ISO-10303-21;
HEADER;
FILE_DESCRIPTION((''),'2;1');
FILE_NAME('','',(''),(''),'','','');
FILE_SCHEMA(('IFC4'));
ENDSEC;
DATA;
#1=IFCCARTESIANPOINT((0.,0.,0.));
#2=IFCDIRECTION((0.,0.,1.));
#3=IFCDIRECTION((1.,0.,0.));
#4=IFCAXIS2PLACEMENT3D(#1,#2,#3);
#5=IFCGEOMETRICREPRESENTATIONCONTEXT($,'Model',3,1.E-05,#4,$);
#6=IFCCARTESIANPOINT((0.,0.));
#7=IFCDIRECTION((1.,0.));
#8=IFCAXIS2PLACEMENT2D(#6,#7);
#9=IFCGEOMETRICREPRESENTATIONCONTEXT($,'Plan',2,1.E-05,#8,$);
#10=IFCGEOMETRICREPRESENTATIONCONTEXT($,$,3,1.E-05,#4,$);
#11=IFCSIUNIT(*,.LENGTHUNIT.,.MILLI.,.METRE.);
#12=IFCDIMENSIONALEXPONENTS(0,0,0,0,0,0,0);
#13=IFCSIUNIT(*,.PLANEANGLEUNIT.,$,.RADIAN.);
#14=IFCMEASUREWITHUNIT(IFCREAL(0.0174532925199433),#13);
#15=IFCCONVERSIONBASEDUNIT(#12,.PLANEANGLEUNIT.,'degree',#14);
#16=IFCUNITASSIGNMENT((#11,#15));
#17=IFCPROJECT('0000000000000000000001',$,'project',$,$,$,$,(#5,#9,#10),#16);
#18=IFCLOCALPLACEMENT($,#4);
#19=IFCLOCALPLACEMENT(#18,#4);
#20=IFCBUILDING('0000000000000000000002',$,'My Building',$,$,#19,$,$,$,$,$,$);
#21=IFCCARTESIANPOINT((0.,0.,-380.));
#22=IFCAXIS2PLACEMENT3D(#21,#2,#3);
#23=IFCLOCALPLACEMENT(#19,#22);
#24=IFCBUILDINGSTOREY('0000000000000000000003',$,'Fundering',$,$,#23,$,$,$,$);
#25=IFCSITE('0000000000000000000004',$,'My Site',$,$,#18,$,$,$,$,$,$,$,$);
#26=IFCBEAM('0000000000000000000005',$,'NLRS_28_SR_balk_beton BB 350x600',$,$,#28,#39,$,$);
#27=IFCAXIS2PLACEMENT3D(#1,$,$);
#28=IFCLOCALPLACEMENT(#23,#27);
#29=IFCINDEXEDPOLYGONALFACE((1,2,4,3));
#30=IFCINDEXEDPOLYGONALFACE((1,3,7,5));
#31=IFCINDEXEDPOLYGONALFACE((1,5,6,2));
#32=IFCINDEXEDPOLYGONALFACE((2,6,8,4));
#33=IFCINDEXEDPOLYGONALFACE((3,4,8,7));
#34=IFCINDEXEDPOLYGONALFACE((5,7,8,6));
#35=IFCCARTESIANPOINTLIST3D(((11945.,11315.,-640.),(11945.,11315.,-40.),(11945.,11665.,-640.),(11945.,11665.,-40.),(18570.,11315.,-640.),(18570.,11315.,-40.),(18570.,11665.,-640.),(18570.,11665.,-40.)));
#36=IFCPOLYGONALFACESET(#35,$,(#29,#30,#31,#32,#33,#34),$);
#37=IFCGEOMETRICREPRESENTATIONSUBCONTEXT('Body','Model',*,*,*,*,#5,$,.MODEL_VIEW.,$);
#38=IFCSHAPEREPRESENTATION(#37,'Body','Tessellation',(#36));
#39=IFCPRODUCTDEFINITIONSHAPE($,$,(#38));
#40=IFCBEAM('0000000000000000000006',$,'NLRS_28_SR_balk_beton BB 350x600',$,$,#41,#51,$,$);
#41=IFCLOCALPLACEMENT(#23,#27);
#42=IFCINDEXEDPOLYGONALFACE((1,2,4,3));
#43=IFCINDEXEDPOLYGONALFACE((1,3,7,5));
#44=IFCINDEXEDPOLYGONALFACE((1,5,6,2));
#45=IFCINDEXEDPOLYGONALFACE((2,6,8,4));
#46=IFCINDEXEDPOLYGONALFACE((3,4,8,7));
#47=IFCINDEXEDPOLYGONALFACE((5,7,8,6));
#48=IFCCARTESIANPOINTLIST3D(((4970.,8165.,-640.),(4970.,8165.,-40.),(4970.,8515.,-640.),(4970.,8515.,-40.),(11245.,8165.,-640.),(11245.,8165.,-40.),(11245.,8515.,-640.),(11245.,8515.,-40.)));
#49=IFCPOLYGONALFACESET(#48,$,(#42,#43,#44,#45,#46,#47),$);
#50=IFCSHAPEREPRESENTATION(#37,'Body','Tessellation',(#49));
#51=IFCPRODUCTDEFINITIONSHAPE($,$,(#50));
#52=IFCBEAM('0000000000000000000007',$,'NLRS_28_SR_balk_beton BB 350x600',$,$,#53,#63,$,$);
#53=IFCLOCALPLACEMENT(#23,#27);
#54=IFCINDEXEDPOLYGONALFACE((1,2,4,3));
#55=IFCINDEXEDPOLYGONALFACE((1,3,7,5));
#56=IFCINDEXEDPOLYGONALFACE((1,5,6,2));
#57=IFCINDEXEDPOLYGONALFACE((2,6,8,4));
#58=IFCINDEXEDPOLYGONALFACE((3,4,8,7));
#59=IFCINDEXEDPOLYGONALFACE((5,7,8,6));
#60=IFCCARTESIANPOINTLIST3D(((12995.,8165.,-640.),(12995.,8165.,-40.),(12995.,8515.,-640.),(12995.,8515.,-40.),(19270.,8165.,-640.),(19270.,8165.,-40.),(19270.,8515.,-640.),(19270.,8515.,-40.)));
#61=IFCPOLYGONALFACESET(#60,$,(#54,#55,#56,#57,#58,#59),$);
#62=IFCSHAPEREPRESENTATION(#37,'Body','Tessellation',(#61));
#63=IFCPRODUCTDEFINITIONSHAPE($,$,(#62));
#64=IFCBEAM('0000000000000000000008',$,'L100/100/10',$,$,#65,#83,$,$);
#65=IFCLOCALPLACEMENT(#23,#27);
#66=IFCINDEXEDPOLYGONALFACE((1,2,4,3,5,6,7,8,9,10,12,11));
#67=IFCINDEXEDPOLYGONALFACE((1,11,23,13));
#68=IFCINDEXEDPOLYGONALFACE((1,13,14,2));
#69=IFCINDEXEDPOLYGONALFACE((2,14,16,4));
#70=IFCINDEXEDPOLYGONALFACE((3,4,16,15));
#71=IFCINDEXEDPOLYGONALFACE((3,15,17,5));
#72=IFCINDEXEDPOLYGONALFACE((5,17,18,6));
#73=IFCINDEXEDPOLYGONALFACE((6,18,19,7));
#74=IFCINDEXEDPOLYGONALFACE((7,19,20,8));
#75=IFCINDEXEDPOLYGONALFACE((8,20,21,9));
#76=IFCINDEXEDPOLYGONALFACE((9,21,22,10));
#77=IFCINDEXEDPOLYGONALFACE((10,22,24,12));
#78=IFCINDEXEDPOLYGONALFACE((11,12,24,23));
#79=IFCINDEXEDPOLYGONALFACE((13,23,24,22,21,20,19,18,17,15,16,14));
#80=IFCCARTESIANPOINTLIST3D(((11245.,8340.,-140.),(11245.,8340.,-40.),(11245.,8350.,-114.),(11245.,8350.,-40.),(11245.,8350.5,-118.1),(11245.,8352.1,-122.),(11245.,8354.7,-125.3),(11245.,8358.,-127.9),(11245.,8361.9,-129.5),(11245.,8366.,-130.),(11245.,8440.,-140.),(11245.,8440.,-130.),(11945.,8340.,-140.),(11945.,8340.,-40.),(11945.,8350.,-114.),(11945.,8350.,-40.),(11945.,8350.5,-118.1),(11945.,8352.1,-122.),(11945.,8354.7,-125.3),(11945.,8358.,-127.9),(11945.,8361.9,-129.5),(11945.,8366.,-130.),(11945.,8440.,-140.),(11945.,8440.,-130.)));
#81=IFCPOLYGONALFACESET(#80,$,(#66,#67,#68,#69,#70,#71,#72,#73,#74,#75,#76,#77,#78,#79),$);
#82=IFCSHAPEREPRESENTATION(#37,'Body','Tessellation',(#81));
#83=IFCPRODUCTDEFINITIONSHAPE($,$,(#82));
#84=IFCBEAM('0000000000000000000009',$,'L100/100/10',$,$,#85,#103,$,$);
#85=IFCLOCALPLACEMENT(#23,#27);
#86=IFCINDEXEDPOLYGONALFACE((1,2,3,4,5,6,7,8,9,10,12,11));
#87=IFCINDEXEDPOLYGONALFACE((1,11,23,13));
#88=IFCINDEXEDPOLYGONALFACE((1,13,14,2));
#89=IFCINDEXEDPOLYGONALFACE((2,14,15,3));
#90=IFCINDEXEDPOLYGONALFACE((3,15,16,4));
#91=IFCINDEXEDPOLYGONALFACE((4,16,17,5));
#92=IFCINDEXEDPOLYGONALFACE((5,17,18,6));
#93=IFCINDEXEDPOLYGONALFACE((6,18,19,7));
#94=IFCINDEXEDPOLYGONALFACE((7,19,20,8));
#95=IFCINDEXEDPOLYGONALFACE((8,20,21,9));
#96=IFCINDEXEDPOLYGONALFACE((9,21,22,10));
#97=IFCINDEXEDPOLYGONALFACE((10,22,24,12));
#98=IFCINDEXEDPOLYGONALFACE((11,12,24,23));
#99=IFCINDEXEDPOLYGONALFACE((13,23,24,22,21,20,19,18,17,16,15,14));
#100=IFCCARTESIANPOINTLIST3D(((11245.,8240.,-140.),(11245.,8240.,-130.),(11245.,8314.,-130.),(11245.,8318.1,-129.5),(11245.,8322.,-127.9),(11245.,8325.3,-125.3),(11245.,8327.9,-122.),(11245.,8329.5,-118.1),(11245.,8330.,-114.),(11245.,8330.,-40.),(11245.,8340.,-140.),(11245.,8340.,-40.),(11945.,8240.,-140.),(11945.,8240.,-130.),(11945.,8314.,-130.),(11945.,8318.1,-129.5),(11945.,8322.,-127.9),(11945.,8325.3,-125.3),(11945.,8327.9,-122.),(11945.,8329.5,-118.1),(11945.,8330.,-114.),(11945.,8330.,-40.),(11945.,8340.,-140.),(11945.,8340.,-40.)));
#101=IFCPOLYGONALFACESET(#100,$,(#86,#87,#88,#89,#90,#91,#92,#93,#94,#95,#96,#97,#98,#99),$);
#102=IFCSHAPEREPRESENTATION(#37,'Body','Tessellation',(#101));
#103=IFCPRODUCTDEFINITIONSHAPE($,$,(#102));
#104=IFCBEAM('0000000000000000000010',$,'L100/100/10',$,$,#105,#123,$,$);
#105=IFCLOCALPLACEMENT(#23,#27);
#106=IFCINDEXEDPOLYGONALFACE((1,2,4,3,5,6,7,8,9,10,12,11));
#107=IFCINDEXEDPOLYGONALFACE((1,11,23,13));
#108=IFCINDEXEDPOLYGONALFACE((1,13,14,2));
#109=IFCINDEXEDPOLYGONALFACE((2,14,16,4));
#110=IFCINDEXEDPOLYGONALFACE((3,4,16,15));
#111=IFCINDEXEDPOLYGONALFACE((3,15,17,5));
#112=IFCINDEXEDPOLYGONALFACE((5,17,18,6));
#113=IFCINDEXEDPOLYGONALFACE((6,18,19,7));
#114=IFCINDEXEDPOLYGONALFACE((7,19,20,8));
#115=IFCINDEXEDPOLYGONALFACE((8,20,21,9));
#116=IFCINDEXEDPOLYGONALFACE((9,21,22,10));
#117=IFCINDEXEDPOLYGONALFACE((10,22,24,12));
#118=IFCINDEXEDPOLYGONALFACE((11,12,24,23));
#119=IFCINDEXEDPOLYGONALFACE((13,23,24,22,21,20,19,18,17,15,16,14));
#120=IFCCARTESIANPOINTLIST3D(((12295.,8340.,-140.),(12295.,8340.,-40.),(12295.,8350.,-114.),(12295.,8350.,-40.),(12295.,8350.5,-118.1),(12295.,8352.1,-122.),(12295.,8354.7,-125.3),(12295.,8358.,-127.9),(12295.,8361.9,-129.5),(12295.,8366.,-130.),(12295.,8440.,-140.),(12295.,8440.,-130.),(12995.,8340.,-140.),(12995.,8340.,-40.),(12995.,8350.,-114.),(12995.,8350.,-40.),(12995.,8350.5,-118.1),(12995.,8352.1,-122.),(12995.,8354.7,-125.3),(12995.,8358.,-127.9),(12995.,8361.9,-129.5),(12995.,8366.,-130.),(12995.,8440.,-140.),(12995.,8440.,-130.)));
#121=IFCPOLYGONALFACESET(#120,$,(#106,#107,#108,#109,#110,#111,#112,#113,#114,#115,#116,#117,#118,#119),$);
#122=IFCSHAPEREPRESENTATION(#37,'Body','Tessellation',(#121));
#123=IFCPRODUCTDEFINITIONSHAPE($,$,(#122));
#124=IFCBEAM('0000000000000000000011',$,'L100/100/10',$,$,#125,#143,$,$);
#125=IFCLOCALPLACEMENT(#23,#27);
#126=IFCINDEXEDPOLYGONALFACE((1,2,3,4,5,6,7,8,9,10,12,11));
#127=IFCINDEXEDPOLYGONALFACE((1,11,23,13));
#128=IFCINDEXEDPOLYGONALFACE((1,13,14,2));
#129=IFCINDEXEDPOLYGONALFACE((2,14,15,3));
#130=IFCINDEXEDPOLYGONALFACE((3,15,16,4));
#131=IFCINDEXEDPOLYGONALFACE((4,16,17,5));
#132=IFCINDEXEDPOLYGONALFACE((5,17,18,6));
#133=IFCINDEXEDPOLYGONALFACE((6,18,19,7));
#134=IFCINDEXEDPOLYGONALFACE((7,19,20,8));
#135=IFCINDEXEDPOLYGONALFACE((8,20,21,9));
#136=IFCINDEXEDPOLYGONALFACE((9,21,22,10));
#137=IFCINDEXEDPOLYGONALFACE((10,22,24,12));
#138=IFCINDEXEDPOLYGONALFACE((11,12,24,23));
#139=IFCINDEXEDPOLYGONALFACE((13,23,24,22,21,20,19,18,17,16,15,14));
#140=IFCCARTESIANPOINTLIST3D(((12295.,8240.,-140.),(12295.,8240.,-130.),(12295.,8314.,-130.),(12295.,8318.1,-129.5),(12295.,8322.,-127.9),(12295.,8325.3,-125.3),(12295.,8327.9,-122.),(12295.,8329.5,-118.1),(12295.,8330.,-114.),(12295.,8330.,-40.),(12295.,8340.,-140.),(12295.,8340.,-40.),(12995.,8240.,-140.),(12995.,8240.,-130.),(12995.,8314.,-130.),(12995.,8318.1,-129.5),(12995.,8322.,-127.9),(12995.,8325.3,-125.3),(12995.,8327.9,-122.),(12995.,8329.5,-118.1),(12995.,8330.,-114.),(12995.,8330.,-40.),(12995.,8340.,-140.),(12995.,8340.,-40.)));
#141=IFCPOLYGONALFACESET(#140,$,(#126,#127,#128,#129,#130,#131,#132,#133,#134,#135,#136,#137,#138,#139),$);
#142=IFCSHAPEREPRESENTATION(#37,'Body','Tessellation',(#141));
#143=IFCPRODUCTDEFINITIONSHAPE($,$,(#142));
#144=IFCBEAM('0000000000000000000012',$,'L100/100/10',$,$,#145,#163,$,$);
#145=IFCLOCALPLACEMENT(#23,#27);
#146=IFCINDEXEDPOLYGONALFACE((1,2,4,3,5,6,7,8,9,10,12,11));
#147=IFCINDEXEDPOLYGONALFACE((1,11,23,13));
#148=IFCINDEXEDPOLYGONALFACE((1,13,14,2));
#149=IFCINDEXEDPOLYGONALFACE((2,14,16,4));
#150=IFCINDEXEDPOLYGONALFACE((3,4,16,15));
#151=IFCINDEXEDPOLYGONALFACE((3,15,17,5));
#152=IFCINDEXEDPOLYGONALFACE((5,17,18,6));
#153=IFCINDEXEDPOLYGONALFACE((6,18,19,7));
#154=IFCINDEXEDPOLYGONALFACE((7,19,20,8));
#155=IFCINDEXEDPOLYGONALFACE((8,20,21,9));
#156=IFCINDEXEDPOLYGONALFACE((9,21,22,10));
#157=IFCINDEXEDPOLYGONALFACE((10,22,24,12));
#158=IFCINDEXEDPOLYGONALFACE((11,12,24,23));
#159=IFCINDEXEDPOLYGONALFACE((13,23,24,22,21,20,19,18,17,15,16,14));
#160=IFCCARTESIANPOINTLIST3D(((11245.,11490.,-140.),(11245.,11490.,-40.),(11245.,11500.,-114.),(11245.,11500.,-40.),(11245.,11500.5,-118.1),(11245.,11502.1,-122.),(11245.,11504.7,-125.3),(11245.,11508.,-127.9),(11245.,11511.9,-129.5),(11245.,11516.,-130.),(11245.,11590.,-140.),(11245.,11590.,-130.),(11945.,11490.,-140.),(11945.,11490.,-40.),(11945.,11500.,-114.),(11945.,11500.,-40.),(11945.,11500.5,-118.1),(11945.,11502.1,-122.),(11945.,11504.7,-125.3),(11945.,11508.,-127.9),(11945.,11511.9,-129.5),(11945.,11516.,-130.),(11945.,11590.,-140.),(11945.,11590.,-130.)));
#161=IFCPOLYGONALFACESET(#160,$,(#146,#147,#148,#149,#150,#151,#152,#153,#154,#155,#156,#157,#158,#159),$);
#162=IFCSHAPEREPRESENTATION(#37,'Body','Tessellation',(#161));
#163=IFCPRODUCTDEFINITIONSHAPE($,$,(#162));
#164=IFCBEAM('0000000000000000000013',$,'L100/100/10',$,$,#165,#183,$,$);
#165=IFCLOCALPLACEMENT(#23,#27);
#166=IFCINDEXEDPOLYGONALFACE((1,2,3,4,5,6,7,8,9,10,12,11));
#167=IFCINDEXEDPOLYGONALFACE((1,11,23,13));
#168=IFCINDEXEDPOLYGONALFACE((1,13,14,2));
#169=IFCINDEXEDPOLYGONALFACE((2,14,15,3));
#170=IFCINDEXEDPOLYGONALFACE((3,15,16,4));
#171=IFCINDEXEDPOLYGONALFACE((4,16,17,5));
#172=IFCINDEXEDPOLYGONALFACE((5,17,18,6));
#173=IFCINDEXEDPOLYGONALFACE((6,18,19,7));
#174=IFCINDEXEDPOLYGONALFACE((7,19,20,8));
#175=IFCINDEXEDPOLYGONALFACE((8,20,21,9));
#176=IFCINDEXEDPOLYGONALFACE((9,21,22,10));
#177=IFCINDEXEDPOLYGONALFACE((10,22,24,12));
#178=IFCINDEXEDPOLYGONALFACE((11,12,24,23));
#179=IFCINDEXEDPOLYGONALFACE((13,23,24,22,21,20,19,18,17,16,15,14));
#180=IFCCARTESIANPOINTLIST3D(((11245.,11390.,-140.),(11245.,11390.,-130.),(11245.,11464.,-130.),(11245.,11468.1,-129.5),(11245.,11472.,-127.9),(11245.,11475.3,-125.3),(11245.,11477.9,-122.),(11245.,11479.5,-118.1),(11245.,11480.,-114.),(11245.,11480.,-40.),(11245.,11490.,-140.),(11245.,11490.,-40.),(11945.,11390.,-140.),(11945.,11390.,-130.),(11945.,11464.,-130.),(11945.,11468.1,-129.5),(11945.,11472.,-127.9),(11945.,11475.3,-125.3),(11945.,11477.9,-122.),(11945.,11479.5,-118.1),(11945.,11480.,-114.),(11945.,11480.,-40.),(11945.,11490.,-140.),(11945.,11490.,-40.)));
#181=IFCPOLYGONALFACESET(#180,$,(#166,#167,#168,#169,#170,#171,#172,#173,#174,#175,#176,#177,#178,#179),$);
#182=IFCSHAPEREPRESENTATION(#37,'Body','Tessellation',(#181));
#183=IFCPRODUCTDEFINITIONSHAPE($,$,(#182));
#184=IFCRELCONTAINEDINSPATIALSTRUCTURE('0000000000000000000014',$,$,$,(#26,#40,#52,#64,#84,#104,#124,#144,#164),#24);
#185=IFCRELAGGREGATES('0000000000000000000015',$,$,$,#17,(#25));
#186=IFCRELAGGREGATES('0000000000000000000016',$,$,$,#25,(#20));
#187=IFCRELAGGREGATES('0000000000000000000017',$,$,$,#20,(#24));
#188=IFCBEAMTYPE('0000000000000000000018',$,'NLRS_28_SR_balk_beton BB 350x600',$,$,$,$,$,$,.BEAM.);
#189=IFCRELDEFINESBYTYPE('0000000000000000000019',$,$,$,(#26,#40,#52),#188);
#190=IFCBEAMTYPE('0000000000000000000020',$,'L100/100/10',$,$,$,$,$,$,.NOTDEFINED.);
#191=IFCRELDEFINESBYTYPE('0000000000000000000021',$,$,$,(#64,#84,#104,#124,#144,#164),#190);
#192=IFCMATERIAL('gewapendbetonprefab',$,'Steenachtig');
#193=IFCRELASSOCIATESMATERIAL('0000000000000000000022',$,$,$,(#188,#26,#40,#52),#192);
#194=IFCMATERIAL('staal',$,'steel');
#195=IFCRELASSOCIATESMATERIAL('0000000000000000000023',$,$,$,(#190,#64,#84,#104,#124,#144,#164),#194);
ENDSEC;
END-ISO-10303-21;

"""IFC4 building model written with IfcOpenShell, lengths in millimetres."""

from ifc_helpers import new_model, entity, si_unit, converted_unit, frame, origin_with_axes, origin_2d_with_axis, place, context, subcontext, project, spatial, rectangle, l_section, extrude, material, material_profile, profile_set, profile_usage, type_object, element, save


model = new_model("IFC4")

# Units and contexts
model_context = context("Model", 3, precision=1e-05, world=origin_with_axes())
plan_context = context("Plan", 2, precision=1e-05, world=origin_2d_with_axis())
context_of_model = context(None, 3, precision=1e-05, world=origin_with_axes())
body_context = subcontext(model_context, "Body", "Model", "MODEL_VIEW")
ifc_project = project(units=[si_unit("LENGTHUNIT", "METRE", prefix="MILLI"), converted_unit("PLANEANGLEUNIT", "degree", entity("IfcReal", 0.0174532925199433), si_unit("PLANEANGLEUNIT", "RADIAN"), dimensions=[0, 0, 0, 0, 0, 0, 0])], contexts=[model_context, plan_context, context_of_model])

# Site, building, storey
site_placement = place(None, origin_with_axes())
site = spatial("IfcSite", under=ifc_project, at=site_placement, Name="My Site")
building_placement = place(site_placement, origin_with_axes())
building = spatial("IfcBuilding", under=site, at=building_placement, Name="My Building")
storey_placement = place(building_placement, frame((0.0, 0.0, -380.0), z_axis=(0.0, 0.0, 1.0), x_axis=(1.0, 0.0, 0.0)))
storey = spatial("IfcBuildingStorey", under=building, at=storey_placement, Name="Fundering")

# Beams
ifc_material_1 = material(Name="gewapendbetonprefab", Category="Steenachtig")
ifc_material_profile_1 = material_profile(ifc_material_1, rectangle(XDim=350.0, YDim=600.0))
ifc_profile_set_1 = profile_set([ifc_material_profile_1], Name="NLRS_28_SR_balk_beton BB 350x600")
beam_type_1 = type_object("IfcBeamType", Name="NLRS_28_SR_balk_beton BB 350x600", PredefinedType="BEAM", material=ifc_profile_set_1)
ifc_profile_usage_1 = profile_usage(ifc_profile_set_1, cardinal=8)
beam_1_placement = place(storey_placement, frame((18570.0, 11490.0, -40.0), z_axis=(-1.0, 0.0, 0.0), x_axis=(0.0, -1.0, 0.0)))
element("IfcBeam", 1, at=beam_1_placement, inside=storey, type_object=beam_type_1, material=ifc_profile_usage_1, Name="NLRS_28_SR_balk_beton BB 350x600", context=body_context, shape_type="SweptSolid", body=[
    extrude(rectangle(XDim=350.0, YDim=600.0), frame((0.0, -300.0, 0.0), z_axis=(0.0, 0.0, 1.0), x_axis=(1.0, 0.0, 0.0)), (0.0, 0.0, 1.0), 6625.0),
])
ifc_profile_usage_2 = profile_usage(ifc_profile_set_1, cardinal=8)
beam_2_placement = place(storey_placement, frame((11245.0, 8340.0, -40.0), z_axis=(-1.0, 0.0, 0.0), x_axis=(0.0, -1.0, 0.0)))
element("IfcBeam", 2, at=beam_2_placement, inside=storey, type_object=beam_type_1, material=ifc_profile_usage_2, Name="NLRS_28_SR_balk_beton BB 350x600", context=body_context, shape_type="SweptSolid", body=[
    extrude(rectangle(XDim=350.0, YDim=600.0), frame((0.0, -300.0, 0.0), z_axis=(0.0, 0.0, 1.0), x_axis=(1.0, 0.0, 0.0)), (0.0, 0.0, 1.0), 6275.0),
])
ifc_profile_usage_3 = profile_usage(ifc_profile_set_1, cardinal=8)
beam_3_placement = place(storey_placement, frame((19270.0, 8340.0, -40.0), z_axis=(-1.0, 0.0, 0.0), x_axis=(0.0, -1.0, 0.0)))
element("IfcBeam", 3, at=beam_3_placement, inside=storey, type_object=beam_type_1, material=ifc_profile_usage_3, Name="NLRS_28_SR_balk_beton BB 350x600", context=body_context, shape_type="SweptSolid", body=[
    extrude(rectangle(XDim=350.0, YDim=600.0), frame((0.0, -300.0, 0.0), z_axis=(0.0, 0.0, 1.0), x_axis=(1.0, 0.0, 0.0)), (0.0, 0.0, 1.0), 6275.0),
])
ifc_material_2 = material(Name="staal", Category="steel")
ifc_material_profile_2 = material_profile(ifc_material_2, l_section(Depth=100.0, Width=100.0, Thickness=10.0, FilletRadius=16.0))
ifc_profile_set_2 = profile_set([ifc_material_profile_2], Name="L100/100/10")
ifc_profile_usage_4 = profile_usage(ifc_profile_set_2, cardinal=5)
beam_type_2 = type_object("IfcBeamType", Name="L100/100/10", PredefinedType="NOTDEFINED", material=ifc_profile_set_2)
beam_4_placement = place(storey_placement, frame((11245.0, 8390.0, -90.0), z_axis=(1.0, 0.0, 0.0), x_axis=(0.0, 1.0, 0.0)))
element("IfcBeam", 4, at=beam_4_placement, inside=storey, type_object=beam_type_2, material=ifc_profile_usage_4, Name="L100/100/10", context=body_context, shape_type="SweptSolid", body=[
    extrude(l_section(Depth=100.0, Width=100.0, Thickness=10.0, FilletRadius=16.0), origin_with_axes(), (0.0, 0.0, 1.0), 700.0),
])
ifc_profile_usage_5 = profile_usage(ifc_profile_set_2, cardinal=5)
beam_5_placement = place(storey_placement, frame((11945.0, 8290.0, -90.0), z_axis=(-1.0, 0.0, 0.0), x_axis=(0.0, -1.0, 0.0)))
element("IfcBeam", 5, at=beam_5_placement, inside=storey, type_object=beam_type_2, material=ifc_profile_usage_5, Name="L100/100/10", context=body_context, shape_type="SweptSolid", body=[
    extrude(l_section(Depth=100.0, Width=100.0, Thickness=10.0, FilletRadius=16.0), origin_with_axes(), (0.0, 0.0, 1.0), 700.0),
])
ifc_profile_usage_6 = profile_usage(ifc_profile_set_2, cardinal=5)
beam_6_placement = place(storey_placement, frame((12295.0, 8390.0, -90.0), z_axis=(1.0, 0.0, 0.0), x_axis=(0.0, 1.0, 0.0)))
element("IfcBeam", 6, at=beam_6_placement, inside=storey, type_object=beam_type_2, material=ifc_profile_usage_6, Name="L100/100/10", context=body_context, shape_type="SweptSolid", body=[
    extrude(l_section(Depth=100.0, Width=100.0, Thickness=10.0, FilletRadius=16.0), origin_with_axes(), (0.0, 0.0, 1.0), 700.0),
])
ifc_profile_usage_7 = profile_usage(ifc_profile_set_2, cardinal=5)
beam_7_placement = place(storey_placement, frame((12995.0, 8290.0, -90.0), z_axis=(-1.0, 0.0, 0.0), x_axis=(0.0, -1.0, 0.0)))
element("IfcBeam", 7, at=beam_7_placement, inside=storey, type_object=beam_type_2, material=ifc_profile_usage_7, Name="L100/100/10", context=body_context, shape_type="SweptSolid", body=[
    extrude(l_section(Depth=100.0, Width=100.0, Thickness=10.0, FilletRadius=16.0), origin_with_axes(), (0.0, 0.0, 1.0), 700.0),
])
ifc_profile_usage_8 = profile_usage(ifc_profile_set_2, cardinal=5)
beam_8_placement = place(storey_placement, frame((11245.0, 11540.0, -90.0), z_axis=(1.0, 0.0, 0.0), x_axis=(0.0, 1.0, 0.0)))
element("IfcBeam", 8, at=beam_8_placement, inside=storey, type_object=beam_type_2, material=ifc_profile_usage_8, Name="L100/100/10", context=body_context, shape_type="SweptSolid", body=[
    extrude(l_section(Depth=100.0, Width=100.0, Thickness=10.0, FilletRadius=16.0), origin_with_axes(), (0.0, 0.0, 1.0), 700.0),
])
ifc_profile_usage_9 = profile_usage(ifc_profile_set_2, cardinal=5)
beam_9_placement = place(storey_placement, frame((11945.0, 11440.0, -90.0), z_axis=(-1.0, 0.0, 0.0), x_axis=(0.0, -1.0, 0.0)))
element("IfcBeam", 9, at=beam_9_placement, inside=storey, type_object=beam_type_2, material=ifc_profile_usage_9, Name="L100/100/10", context=body_context, shape_type="SweptSolid", body=[
    extrude(l_section(Depth=100.0, Width=100.0, Thickness=10.0, FilletRadius=16.0), origin_with_axes(), (0.0, 0.0, 1.0), 700.0),
])

save(model, "model.ifc")
